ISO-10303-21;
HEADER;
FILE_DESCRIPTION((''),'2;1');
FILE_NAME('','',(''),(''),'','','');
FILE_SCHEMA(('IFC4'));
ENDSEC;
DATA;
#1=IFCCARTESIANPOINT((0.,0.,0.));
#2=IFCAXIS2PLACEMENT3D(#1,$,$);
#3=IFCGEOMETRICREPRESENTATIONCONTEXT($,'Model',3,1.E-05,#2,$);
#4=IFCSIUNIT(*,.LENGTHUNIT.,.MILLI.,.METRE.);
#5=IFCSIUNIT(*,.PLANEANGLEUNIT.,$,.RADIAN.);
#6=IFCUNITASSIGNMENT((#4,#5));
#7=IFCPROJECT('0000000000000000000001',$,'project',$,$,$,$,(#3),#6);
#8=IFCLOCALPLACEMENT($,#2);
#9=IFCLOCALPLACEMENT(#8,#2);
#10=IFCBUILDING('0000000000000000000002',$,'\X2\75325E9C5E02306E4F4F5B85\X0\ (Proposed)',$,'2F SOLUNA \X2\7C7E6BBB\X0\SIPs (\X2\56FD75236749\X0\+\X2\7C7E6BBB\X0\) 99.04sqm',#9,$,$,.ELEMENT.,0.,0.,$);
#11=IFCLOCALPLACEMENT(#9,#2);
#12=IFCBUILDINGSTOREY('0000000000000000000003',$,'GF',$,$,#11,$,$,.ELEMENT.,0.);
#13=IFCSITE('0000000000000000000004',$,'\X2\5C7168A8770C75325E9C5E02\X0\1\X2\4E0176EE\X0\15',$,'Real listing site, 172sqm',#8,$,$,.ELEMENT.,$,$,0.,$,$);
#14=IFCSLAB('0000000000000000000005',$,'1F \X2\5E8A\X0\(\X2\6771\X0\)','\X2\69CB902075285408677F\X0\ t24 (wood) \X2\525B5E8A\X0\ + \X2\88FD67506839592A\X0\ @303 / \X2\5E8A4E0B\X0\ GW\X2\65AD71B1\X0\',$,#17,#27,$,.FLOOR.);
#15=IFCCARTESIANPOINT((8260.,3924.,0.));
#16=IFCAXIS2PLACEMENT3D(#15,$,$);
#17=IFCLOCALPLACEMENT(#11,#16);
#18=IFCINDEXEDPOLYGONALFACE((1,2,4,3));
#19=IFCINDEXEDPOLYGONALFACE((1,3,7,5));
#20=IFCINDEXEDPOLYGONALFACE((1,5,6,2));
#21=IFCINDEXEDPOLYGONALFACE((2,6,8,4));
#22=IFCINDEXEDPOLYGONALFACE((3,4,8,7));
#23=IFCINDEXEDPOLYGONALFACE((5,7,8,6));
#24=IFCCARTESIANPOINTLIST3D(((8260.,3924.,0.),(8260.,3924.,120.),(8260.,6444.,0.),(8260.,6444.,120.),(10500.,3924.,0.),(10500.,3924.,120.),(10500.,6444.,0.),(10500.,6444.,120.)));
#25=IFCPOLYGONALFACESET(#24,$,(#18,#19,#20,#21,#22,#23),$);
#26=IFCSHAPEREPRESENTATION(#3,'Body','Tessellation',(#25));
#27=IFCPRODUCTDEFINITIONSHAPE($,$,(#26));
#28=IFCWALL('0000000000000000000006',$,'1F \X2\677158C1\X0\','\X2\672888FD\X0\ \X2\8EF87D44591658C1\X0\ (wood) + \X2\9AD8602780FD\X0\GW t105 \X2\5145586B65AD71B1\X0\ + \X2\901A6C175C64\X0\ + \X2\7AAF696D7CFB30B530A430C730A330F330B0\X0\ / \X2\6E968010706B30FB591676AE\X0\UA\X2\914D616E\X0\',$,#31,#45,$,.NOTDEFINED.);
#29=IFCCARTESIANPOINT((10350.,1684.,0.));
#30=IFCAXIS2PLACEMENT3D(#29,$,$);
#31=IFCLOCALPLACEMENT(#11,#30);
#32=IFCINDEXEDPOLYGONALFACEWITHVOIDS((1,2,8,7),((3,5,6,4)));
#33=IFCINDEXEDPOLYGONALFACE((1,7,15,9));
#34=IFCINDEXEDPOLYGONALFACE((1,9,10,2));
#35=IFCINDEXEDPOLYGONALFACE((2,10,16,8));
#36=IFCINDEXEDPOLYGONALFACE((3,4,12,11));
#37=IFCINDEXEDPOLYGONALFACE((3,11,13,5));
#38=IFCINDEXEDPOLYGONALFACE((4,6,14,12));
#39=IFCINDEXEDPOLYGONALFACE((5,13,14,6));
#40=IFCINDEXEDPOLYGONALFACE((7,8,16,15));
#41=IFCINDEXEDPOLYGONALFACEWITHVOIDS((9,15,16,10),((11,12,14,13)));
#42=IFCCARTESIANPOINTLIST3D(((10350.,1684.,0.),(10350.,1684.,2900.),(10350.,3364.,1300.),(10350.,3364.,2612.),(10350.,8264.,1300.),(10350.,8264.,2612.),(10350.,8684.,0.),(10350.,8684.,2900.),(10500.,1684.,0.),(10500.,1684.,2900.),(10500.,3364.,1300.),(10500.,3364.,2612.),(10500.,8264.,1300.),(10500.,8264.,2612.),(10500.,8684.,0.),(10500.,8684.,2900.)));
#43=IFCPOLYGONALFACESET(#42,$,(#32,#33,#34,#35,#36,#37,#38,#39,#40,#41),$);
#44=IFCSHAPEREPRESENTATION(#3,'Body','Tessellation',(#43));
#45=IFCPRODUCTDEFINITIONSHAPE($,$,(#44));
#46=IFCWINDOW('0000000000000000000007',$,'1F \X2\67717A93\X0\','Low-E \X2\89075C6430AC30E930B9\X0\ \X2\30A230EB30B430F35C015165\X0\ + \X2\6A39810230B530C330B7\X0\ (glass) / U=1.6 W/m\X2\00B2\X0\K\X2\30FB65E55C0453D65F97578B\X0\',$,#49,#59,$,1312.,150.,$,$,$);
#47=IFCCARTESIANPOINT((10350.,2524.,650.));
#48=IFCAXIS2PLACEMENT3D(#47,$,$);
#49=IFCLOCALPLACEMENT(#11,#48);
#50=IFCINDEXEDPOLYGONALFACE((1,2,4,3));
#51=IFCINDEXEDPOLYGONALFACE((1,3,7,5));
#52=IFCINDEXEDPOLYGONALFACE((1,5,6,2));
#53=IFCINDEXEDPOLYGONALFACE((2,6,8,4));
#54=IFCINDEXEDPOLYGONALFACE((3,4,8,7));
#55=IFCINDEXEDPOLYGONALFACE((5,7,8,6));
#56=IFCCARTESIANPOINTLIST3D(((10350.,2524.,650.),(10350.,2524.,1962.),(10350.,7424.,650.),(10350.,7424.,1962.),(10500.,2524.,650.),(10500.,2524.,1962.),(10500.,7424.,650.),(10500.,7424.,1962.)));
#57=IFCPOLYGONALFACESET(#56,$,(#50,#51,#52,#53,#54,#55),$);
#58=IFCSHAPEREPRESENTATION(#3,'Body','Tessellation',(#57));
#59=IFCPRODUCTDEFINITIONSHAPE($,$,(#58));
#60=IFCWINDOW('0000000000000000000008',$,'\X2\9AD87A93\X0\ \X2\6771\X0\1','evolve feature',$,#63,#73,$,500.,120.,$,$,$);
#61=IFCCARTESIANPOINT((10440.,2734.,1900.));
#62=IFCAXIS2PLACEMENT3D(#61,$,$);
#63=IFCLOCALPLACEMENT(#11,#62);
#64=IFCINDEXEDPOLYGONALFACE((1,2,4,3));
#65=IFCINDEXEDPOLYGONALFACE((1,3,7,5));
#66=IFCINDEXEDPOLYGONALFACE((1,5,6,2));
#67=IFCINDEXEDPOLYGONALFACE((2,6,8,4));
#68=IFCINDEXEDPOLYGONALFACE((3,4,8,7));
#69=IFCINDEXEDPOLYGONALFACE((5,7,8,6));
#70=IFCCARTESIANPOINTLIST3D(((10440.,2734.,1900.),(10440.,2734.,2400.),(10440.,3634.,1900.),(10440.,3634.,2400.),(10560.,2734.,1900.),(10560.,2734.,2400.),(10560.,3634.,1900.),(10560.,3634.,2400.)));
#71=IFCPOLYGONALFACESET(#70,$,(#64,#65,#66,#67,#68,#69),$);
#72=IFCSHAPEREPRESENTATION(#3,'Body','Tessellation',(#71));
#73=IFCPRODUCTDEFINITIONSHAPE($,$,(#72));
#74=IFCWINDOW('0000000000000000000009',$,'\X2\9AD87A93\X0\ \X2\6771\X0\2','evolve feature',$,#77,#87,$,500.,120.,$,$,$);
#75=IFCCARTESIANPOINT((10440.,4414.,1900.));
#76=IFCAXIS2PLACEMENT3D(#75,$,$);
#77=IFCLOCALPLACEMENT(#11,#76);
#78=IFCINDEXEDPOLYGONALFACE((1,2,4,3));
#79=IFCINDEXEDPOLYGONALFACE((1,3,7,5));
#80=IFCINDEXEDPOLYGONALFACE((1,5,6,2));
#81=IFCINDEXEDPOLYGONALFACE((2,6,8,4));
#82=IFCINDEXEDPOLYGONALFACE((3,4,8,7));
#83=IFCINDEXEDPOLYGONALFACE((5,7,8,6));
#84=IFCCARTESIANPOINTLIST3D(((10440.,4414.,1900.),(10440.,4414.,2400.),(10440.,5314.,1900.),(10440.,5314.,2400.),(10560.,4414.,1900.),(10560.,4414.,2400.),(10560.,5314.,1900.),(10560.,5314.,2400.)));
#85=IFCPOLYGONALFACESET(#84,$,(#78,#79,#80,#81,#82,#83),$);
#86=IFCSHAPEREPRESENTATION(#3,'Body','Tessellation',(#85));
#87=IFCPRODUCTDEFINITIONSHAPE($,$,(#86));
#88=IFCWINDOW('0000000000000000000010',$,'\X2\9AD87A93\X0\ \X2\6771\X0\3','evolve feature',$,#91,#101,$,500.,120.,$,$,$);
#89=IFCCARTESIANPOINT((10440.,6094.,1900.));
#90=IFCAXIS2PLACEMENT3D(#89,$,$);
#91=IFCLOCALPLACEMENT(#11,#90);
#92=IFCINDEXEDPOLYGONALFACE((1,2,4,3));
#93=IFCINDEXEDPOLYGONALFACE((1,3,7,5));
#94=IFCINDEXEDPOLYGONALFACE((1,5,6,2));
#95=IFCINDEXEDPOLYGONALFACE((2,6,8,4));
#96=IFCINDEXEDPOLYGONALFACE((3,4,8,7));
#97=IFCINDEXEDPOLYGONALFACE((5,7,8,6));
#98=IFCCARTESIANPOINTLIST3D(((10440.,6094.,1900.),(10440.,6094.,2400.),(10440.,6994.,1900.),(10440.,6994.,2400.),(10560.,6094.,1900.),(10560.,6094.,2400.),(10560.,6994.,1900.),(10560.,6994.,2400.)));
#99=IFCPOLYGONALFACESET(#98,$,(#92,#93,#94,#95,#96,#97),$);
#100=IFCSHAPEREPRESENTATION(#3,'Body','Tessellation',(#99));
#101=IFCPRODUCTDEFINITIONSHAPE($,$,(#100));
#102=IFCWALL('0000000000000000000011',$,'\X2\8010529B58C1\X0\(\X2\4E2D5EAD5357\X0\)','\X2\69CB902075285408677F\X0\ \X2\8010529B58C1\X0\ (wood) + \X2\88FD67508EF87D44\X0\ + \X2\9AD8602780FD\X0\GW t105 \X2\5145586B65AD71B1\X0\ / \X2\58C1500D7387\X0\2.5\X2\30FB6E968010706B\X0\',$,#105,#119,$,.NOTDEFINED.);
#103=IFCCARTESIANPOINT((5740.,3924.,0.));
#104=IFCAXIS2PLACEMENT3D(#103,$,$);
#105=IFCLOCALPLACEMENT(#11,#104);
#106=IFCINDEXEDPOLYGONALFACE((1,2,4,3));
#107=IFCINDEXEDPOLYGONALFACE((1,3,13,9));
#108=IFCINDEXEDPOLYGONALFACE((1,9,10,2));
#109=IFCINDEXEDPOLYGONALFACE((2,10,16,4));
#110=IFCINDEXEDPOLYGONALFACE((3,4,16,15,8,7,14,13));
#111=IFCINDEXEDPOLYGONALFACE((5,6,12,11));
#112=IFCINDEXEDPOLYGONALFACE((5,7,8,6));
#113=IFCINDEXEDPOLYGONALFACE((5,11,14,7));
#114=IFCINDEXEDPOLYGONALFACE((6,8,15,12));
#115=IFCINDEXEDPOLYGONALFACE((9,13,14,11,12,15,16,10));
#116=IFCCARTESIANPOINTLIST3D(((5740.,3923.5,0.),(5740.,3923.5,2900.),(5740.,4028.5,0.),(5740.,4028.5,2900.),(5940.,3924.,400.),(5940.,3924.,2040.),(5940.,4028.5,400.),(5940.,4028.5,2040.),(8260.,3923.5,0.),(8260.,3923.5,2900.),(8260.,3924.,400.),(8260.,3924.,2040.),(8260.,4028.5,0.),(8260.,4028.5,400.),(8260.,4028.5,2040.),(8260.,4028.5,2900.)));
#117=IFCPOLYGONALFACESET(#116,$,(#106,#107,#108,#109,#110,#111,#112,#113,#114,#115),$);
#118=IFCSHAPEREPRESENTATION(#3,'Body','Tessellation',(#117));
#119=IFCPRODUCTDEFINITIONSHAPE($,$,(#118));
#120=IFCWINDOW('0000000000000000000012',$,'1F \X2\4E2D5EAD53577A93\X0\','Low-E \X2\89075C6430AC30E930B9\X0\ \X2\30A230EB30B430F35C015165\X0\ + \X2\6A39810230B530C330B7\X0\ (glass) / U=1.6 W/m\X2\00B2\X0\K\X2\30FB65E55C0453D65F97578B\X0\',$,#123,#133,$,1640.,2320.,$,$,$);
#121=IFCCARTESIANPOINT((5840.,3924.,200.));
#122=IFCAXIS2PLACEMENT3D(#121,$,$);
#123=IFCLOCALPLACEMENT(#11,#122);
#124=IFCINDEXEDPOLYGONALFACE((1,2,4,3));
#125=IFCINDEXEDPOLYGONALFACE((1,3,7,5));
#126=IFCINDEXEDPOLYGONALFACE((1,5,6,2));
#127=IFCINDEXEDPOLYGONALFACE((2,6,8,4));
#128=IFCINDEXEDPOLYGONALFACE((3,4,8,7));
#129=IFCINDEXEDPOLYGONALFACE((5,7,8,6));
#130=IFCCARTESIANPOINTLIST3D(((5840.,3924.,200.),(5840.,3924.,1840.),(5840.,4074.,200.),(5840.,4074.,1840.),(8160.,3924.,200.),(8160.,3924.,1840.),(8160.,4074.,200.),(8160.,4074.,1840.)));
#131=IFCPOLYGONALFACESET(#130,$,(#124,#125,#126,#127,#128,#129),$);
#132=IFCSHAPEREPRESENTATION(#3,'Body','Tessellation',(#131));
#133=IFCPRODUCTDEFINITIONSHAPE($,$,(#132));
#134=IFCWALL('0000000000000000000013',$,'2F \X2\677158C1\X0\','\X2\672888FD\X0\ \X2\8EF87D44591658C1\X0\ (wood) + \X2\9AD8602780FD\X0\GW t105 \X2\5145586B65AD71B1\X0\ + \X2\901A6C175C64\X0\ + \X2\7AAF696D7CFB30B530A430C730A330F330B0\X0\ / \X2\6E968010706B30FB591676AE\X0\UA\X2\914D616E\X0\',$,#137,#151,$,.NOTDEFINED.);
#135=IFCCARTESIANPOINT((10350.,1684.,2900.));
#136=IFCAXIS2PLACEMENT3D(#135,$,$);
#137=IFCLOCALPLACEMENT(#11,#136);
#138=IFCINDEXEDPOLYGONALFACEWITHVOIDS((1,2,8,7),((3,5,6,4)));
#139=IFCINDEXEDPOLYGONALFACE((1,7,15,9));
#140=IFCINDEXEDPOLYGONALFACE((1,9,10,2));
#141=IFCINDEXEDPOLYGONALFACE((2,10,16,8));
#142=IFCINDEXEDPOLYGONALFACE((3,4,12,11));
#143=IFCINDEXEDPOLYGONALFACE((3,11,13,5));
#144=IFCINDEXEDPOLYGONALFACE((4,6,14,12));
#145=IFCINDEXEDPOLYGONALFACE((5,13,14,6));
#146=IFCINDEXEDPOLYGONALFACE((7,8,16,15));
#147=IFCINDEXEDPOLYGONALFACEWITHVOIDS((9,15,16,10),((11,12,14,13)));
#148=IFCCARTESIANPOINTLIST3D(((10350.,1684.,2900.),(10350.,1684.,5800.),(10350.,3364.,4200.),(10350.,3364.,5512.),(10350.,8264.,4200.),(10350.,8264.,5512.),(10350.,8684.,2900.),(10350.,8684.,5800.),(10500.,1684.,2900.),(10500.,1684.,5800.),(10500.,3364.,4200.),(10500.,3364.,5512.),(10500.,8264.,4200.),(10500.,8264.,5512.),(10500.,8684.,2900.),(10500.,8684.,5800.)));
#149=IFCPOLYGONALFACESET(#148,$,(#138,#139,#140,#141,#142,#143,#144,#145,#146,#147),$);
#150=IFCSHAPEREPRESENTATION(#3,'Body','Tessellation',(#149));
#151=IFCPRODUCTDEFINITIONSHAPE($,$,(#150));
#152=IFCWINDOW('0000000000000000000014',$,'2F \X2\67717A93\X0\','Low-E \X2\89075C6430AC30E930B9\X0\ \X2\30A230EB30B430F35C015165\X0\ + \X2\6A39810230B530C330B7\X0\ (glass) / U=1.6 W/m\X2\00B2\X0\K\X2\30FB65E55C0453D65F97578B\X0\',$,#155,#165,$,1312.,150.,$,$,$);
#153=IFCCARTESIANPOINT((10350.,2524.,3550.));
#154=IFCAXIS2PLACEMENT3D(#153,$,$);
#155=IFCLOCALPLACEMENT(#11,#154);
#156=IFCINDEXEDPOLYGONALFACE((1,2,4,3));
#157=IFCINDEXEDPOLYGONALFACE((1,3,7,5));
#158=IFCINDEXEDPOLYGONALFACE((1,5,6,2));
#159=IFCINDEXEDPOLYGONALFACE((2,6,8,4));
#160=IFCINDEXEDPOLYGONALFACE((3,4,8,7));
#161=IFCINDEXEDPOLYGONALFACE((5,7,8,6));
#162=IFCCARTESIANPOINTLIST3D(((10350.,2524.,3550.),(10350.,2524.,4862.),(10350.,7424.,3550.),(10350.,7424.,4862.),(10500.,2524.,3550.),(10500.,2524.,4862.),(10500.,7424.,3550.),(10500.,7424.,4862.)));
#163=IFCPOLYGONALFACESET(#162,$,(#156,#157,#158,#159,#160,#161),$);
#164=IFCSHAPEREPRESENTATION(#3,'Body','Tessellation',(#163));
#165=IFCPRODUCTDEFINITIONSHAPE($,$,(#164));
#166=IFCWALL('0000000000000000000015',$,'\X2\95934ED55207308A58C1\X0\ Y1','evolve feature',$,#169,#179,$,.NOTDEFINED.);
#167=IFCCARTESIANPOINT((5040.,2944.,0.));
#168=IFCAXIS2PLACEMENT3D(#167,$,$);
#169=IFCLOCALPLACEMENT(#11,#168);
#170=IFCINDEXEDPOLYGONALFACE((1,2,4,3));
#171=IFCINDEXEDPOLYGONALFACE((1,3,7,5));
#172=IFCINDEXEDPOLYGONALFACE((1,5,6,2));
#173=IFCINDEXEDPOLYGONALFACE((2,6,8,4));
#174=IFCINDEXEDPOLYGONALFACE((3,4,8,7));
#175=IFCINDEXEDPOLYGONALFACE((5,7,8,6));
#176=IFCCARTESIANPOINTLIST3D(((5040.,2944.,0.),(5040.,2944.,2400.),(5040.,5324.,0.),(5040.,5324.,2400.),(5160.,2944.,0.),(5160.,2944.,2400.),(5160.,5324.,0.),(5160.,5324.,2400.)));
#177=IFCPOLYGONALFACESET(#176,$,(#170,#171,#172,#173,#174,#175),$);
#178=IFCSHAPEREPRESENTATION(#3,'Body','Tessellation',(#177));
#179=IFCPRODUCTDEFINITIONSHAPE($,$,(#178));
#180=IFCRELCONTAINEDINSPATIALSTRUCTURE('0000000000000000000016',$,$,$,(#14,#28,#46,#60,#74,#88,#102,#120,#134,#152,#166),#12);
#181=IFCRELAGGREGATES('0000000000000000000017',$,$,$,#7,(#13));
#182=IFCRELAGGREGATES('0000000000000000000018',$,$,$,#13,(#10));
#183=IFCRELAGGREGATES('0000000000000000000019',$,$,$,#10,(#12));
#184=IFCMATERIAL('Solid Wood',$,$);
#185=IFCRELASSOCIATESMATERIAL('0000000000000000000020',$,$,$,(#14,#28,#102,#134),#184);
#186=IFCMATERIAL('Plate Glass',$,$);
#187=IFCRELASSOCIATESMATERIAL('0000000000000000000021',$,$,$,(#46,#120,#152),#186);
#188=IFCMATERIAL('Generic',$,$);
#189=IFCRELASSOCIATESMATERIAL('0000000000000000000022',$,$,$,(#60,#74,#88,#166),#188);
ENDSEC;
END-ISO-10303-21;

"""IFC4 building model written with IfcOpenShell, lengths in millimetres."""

from ifc_helpers import new_model, si_unit, frame, frame_2d, origin, place, context, project, spatial, rectangle, extrude, material, element, fill, save


model = new_model("IFC4")

# Units and contexts
model_context = context("Model", 3, precision=1e-05, world=origin())
ifc_project = project(units=[si_unit("LENGTHUNIT", "METRE", prefix="MILLI"), si_unit("PLANEANGLEUNIT", "RADIAN")], contexts=[model_context])

# Site, building, storey
site_placement = place(None, origin())
site = spatial("IfcSite", under=ifc_project, at=site_placement, Name="山梨県甲府市1丁目15", ObjectType="Real listing site, 172sqm", CompositionType="ELEMENT", RefElevation=0.0)
building_placement = place(site_placement, origin())
building = spatial("IfcBuilding", under=site, at=building_placement, Name="甲府市の住宅 (Proposed)", ObjectType="2F SOLUNA 籾殻SIPs (国産杉+籾殻) 99.04sqm", CompositionType="ELEMENT", ElevationOfRefHeight=0.0, ElevationOfTerrain=0.0)
storey_placement = place(building_placement, origin())
storey = spatial("IfcBuildingStorey", under=building, at=storey_placement, Name="GF", CompositionType="ELEMENT", Elevation=0.0)

# Slab
ifc_material_1 = material(Name="Solid Wood")
slab_placement = place(storey_placement, frame((8260.0, 3924.0, 0.0)))
element("IfcSlab", 1, at=slab_placement, inside=storey, material=ifc_material_1, Name="1F 床(東)", Description="構造用合板 t24 (wood) 剛床 + 製材根太 @303 / 床下 GW断熱", PredefinedType="FLOOR", context=model_context, shape_type="SweptSolid", body=[
    extrude(rectangle(XDim=2240.0, YDim=2520.0, at=frame_2d((1120.0, 1260.0))), frame((8260.0, 3924.0, 0.0)), (0.0, 0.0, 1.0), 120.0),
])

# Wall, openings, windows
wall_1_placement = place(storey_placement, frame((10350.0, 1684.0, 0.0)))
wall_1 = element("IfcWall", 2, at=wall_1_placement, inside=storey, material=ifc_material_1, Name="1F 東壁", Description="木製 軸組外壁 (wood) + 高性能GW t105 充填断熱 + 通気層 + 窯業系サイディング / 準耐火・外皮UA配慮", PredefinedType="NOTDEFINED", context=model_context, shape_type="SweptSolid", body=[
    extrude(rectangle(XDim=150.0, YDim=7000.0, at=frame_2d((75.0, 3500.0))), frame((10350.0, 1684.0, 0.0)), (0.0, 0.0, 1.0), 2900.0),
])
opening_1_placement = place(storey_placement, frame((10350.0, 2524.0, 650.0)))
opening_1 = element("IfcOpeningElement", 3, at=opening_1_placement, cuts=wall_1, PredefinedType="NOTDEFINED", context=model_context, shape_type="SweptSolid", body=[
    extrude(rectangle(XDim=150.0, YDim=4900.0, at=frame_2d((75.0, 2450.0))), frame((10350.0, 2524.0, 650.0)), (0.0, 0.0, 1.0), 1312.0),
])
opening_2_placement = place(storey_placement, frame((10440.0, 2734.0, 1900.0)))
opening_2 = element("IfcOpeningElement", 4, at=opening_2_placement, cuts=wall_1, PredefinedType="NOTDEFINED", context=model_context, shape_type="SweptSolid", body=[
    extrude(rectangle(XDim=120.0, YDim=900.0, at=frame_2d((60.0, 450.0))), frame((10440.0, 2734.0, 1900.0)), (0.0, 0.0, 1.0), 500.0),
])
opening_3_placement = place(storey_placement, frame((10440.0, 4414.0, 1900.0)))
opening_3 = element("IfcOpeningElement", 5, at=opening_3_placement, cuts=wall_1, PredefinedType="NOTDEFINED", context=model_context, shape_type="SweptSolid", body=[
    extrude(rectangle(XDim=120.0, YDim=900.0, at=frame_2d((60.0, 450.0))), frame((10440.0, 4414.0, 1900.0)), (0.0, 0.0, 1.0), 500.0),
])
opening_4_placement = place(storey_placement, frame((10440.0, 6094.0, 1900.0)))
opening_4 = element("IfcOpeningElement", 6, at=opening_4_placement, cuts=wall_1, PredefinedType="NOTDEFINED", context=model_context, shape_type="SweptSolid", body=[
    extrude(rectangle(XDim=120.0, YDim=900.0, at=frame_2d((60.0, 450.0))), frame((10440.0, 6094.0, 1900.0)), (0.0, 0.0, 1.0), 500.0),
])
ifc_material_2 = material(Name="Plate Glass")
window_1_placement = place(storey_placement, frame((10350.0, 2524.0, 650.0)))
window_1 = element("IfcWindow", 7, at=window_1_placement, inside=storey, material=ifc_material_2, Name="1F 東窓", Description="Low-E 複層ガラス アルゴン封入 + 樹脂サッシ (glass) / U=1.6 W/m²K・日射取得型", OverallHeight=1312.0, OverallWidth=150.0, context=model_context, shape_type="SweptSolid", body=[
    extrude(rectangle(XDim=150.0, YDim=4900.0, at=frame_2d((75.0, 2450.0))), frame((10350.0, 2524.0, 650.0)), (0.0, 0.0, 1.0), 1312.0),
])
fill(opening_1, window_1)
ifc_material_3 = material(Name="Generic")
window_2_placement = place(storey_placement, frame((10440.0, 2734.0, 1900.0)))
window_2 = element("IfcWindow", 8, at=window_2_placement, inside=storey, material=ifc_material_3, Name="高窓 東1", Description="evolve feature", OverallHeight=500.0, OverallWidth=120.0, context=model_context, shape_type="SweptSolid", body=[
    extrude(rectangle(XDim=120.0, YDim=900.0, at=frame_2d((60.0, 450.0))), frame((10440.0, 2734.0, 1900.0)), (0.0, 0.0, 1.0), 500.0),
])
fill(opening_2, window_2)
window_3_placement = place(storey_placement, frame((10440.0, 4414.0, 1900.0)))
window_3 = element("IfcWindow", 9, at=window_3_placement, inside=storey, material=ifc_material_3, Name="高窓 東2", Description="evolve feature", OverallHeight=500.0, OverallWidth=120.0, context=model_context, shape_type="SweptSolid", body=[
    extrude(rectangle(XDim=120.0, YDim=900.0, at=frame_2d((60.0, 450.0))), frame((10440.0, 4414.0, 1900.0)), (0.0, 0.0, 1.0), 500.0),
])
fill(opening_3, window_3)
window_4_placement = place(storey_placement, frame((10440.0, 6094.0, 1900.0)))
window_4 = element("IfcWindow", 10, at=window_4_placement, inside=storey, material=ifc_material_3, Name="高窓 東3", Description="evolve feature", OverallHeight=500.0, OverallWidth=120.0, context=model_context, shape_type="SweptSolid", body=[
    extrude(rectangle(XDim=120.0, YDim=900.0, at=frame_2d((60.0, 450.0))), frame((10440.0, 6094.0, 1900.0)), (0.0, 0.0, 1.0), 500.0),
])
fill(opening_4, window_4)

# Wall, opening, window
wall_2_placement = place(storey_placement, frame((5740.0, 3924.0, 0.0)))
wall_2 = element("IfcWall", 11, at=wall_2_placement, inside=storey, material=ifc_material_1, Name="耐力壁(中庭南)", Description="構造用合板 耐力壁 (wood) + 製材軸組 + 高性能GW t105 充填断熱 / 壁倍率2.5・準耐火", PredefinedType="NOTDEFINED", context=model_context, shape_type="SweptSolid", body=[
    extrude(rectangle(XDim=2520.0, YDim=105.0, at=frame_2d((1260.0, 52.0))), frame((5740.0, 3924.0, 0.0)), (0.0, 0.0, 1.0), 2900.0),
])
opening_5_placement = place(storey_placement, frame((5840.0, 3924.0, 200.0)))
opening_5 = element("IfcOpeningElement", 12, at=opening_5_placement, cuts=wall_2, PredefinedType="NOTDEFINED", context=model_context, shape_type="SweptSolid", body=[
    extrude(rectangle(XDim=2320.0, YDim=150.0, at=frame_2d((1160.0, 75.0))), frame((5840.0, 3924.0, 200.0)), (0.0, 0.0, 1.0), 1640.0),
])
window_5_placement = place(storey_placement, frame((5840.0, 3924.0, 200.0)))
window_5 = element("IfcWindow", 13, at=window_5_placement, inside=storey, material=ifc_material_2, Name="1F 中庭南窓", Description="Low-E 複層ガラス アルゴン封入 + 樹脂サッシ (glass) / U=1.6 W/m²K・日射取得型", OverallHeight=1640.0, OverallWidth=2320.0, context=model_context, shape_type="SweptSolid", body=[
    extrude(rectangle(XDim=2320.0, YDim=150.0, at=frame_2d((1160.0, 75.0))), frame((5840.0, 3924.0, 200.0)), (0.0, 0.0, 1.0), 1640.0),
])
fill(opening_5, window_5)

# Wall, opening, window
wall_3_placement = place(storey_placement, frame((10350.0, 1684.0, 2900.0)))
wall_3 = element("IfcWall", 14, at=wall_3_placement, inside=storey, material=ifc_material_1, Name="2F 東壁", Description="木製 軸組外壁 (wood) + 高性能GW t105 充填断熱 + 通気層 + 窯業系サイディング / 準耐火・外皮UA配慮", PredefinedType="NOTDEFINED", context=model_context, shape_type="SweptSolid", body=[
    extrude(rectangle(XDim=150.0, YDim=7000.0, at=frame_2d((75.0, 3500.0))), frame((10350.0, 1684.0, 2900.0)), (0.0, 0.0, 1.0), 2900.0),
])
opening_6_placement = place(storey_placement, frame((10350.0, 2524.0, 3550.0)))
opening_6 = element("IfcOpeningElement", 15, at=opening_6_placement, cuts=wall_3, PredefinedType="NOTDEFINED", context=model_context, shape_type="SweptSolid", body=[
    extrude(rectangle(XDim=150.0, YDim=4900.0, at=frame_2d((75.0, 2450.0))), frame((10350.0, 2524.0, 3550.0)), (0.0, 0.0, 1.0), 1312.0),
])
window_6_placement = place(storey_placement, frame((10350.0, 2524.0, 3550.0)))
window_6 = element("IfcWindow", 16, at=window_6_placement, inside=storey, material=ifc_material_2, Name="2F 東窓", Description="Low-E 複層ガラス アルゴン封入 + 樹脂サッシ (glass) / U=1.6 W/m²K・日射取得型", OverallHeight=1312.0, OverallWidth=150.0, context=model_context, shape_type="SweptSolid", body=[
    extrude(rectangle(XDim=150.0, YDim=4900.0, at=frame_2d((75.0, 2450.0))), frame((10350.0, 2524.0, 3550.0)), (0.0, 0.0, 1.0), 1312.0),
])
fill(opening_6, window_6)

# Wall
wall_4_placement = place(storey_placement, frame((5040.0, 2944.0, 0.0)))
element("IfcWall", 17, at=wall_4_placement, inside=storey, material=ifc_material_3, Name="間仕切り壁 Y1", Description="evolve feature", PredefinedType="NOTDEFINED", context=model_context, shape_type="SweptSolid", body=[
    extrude(rectangle(XDim=120.0, YDim=2380.0, at=frame_2d((60.0, 1190.0))), frame((5040.0, 2944.0, 0.0)), (0.0, 0.0, 1.0), 2400.0),
])

save(model, "model.ifc")
